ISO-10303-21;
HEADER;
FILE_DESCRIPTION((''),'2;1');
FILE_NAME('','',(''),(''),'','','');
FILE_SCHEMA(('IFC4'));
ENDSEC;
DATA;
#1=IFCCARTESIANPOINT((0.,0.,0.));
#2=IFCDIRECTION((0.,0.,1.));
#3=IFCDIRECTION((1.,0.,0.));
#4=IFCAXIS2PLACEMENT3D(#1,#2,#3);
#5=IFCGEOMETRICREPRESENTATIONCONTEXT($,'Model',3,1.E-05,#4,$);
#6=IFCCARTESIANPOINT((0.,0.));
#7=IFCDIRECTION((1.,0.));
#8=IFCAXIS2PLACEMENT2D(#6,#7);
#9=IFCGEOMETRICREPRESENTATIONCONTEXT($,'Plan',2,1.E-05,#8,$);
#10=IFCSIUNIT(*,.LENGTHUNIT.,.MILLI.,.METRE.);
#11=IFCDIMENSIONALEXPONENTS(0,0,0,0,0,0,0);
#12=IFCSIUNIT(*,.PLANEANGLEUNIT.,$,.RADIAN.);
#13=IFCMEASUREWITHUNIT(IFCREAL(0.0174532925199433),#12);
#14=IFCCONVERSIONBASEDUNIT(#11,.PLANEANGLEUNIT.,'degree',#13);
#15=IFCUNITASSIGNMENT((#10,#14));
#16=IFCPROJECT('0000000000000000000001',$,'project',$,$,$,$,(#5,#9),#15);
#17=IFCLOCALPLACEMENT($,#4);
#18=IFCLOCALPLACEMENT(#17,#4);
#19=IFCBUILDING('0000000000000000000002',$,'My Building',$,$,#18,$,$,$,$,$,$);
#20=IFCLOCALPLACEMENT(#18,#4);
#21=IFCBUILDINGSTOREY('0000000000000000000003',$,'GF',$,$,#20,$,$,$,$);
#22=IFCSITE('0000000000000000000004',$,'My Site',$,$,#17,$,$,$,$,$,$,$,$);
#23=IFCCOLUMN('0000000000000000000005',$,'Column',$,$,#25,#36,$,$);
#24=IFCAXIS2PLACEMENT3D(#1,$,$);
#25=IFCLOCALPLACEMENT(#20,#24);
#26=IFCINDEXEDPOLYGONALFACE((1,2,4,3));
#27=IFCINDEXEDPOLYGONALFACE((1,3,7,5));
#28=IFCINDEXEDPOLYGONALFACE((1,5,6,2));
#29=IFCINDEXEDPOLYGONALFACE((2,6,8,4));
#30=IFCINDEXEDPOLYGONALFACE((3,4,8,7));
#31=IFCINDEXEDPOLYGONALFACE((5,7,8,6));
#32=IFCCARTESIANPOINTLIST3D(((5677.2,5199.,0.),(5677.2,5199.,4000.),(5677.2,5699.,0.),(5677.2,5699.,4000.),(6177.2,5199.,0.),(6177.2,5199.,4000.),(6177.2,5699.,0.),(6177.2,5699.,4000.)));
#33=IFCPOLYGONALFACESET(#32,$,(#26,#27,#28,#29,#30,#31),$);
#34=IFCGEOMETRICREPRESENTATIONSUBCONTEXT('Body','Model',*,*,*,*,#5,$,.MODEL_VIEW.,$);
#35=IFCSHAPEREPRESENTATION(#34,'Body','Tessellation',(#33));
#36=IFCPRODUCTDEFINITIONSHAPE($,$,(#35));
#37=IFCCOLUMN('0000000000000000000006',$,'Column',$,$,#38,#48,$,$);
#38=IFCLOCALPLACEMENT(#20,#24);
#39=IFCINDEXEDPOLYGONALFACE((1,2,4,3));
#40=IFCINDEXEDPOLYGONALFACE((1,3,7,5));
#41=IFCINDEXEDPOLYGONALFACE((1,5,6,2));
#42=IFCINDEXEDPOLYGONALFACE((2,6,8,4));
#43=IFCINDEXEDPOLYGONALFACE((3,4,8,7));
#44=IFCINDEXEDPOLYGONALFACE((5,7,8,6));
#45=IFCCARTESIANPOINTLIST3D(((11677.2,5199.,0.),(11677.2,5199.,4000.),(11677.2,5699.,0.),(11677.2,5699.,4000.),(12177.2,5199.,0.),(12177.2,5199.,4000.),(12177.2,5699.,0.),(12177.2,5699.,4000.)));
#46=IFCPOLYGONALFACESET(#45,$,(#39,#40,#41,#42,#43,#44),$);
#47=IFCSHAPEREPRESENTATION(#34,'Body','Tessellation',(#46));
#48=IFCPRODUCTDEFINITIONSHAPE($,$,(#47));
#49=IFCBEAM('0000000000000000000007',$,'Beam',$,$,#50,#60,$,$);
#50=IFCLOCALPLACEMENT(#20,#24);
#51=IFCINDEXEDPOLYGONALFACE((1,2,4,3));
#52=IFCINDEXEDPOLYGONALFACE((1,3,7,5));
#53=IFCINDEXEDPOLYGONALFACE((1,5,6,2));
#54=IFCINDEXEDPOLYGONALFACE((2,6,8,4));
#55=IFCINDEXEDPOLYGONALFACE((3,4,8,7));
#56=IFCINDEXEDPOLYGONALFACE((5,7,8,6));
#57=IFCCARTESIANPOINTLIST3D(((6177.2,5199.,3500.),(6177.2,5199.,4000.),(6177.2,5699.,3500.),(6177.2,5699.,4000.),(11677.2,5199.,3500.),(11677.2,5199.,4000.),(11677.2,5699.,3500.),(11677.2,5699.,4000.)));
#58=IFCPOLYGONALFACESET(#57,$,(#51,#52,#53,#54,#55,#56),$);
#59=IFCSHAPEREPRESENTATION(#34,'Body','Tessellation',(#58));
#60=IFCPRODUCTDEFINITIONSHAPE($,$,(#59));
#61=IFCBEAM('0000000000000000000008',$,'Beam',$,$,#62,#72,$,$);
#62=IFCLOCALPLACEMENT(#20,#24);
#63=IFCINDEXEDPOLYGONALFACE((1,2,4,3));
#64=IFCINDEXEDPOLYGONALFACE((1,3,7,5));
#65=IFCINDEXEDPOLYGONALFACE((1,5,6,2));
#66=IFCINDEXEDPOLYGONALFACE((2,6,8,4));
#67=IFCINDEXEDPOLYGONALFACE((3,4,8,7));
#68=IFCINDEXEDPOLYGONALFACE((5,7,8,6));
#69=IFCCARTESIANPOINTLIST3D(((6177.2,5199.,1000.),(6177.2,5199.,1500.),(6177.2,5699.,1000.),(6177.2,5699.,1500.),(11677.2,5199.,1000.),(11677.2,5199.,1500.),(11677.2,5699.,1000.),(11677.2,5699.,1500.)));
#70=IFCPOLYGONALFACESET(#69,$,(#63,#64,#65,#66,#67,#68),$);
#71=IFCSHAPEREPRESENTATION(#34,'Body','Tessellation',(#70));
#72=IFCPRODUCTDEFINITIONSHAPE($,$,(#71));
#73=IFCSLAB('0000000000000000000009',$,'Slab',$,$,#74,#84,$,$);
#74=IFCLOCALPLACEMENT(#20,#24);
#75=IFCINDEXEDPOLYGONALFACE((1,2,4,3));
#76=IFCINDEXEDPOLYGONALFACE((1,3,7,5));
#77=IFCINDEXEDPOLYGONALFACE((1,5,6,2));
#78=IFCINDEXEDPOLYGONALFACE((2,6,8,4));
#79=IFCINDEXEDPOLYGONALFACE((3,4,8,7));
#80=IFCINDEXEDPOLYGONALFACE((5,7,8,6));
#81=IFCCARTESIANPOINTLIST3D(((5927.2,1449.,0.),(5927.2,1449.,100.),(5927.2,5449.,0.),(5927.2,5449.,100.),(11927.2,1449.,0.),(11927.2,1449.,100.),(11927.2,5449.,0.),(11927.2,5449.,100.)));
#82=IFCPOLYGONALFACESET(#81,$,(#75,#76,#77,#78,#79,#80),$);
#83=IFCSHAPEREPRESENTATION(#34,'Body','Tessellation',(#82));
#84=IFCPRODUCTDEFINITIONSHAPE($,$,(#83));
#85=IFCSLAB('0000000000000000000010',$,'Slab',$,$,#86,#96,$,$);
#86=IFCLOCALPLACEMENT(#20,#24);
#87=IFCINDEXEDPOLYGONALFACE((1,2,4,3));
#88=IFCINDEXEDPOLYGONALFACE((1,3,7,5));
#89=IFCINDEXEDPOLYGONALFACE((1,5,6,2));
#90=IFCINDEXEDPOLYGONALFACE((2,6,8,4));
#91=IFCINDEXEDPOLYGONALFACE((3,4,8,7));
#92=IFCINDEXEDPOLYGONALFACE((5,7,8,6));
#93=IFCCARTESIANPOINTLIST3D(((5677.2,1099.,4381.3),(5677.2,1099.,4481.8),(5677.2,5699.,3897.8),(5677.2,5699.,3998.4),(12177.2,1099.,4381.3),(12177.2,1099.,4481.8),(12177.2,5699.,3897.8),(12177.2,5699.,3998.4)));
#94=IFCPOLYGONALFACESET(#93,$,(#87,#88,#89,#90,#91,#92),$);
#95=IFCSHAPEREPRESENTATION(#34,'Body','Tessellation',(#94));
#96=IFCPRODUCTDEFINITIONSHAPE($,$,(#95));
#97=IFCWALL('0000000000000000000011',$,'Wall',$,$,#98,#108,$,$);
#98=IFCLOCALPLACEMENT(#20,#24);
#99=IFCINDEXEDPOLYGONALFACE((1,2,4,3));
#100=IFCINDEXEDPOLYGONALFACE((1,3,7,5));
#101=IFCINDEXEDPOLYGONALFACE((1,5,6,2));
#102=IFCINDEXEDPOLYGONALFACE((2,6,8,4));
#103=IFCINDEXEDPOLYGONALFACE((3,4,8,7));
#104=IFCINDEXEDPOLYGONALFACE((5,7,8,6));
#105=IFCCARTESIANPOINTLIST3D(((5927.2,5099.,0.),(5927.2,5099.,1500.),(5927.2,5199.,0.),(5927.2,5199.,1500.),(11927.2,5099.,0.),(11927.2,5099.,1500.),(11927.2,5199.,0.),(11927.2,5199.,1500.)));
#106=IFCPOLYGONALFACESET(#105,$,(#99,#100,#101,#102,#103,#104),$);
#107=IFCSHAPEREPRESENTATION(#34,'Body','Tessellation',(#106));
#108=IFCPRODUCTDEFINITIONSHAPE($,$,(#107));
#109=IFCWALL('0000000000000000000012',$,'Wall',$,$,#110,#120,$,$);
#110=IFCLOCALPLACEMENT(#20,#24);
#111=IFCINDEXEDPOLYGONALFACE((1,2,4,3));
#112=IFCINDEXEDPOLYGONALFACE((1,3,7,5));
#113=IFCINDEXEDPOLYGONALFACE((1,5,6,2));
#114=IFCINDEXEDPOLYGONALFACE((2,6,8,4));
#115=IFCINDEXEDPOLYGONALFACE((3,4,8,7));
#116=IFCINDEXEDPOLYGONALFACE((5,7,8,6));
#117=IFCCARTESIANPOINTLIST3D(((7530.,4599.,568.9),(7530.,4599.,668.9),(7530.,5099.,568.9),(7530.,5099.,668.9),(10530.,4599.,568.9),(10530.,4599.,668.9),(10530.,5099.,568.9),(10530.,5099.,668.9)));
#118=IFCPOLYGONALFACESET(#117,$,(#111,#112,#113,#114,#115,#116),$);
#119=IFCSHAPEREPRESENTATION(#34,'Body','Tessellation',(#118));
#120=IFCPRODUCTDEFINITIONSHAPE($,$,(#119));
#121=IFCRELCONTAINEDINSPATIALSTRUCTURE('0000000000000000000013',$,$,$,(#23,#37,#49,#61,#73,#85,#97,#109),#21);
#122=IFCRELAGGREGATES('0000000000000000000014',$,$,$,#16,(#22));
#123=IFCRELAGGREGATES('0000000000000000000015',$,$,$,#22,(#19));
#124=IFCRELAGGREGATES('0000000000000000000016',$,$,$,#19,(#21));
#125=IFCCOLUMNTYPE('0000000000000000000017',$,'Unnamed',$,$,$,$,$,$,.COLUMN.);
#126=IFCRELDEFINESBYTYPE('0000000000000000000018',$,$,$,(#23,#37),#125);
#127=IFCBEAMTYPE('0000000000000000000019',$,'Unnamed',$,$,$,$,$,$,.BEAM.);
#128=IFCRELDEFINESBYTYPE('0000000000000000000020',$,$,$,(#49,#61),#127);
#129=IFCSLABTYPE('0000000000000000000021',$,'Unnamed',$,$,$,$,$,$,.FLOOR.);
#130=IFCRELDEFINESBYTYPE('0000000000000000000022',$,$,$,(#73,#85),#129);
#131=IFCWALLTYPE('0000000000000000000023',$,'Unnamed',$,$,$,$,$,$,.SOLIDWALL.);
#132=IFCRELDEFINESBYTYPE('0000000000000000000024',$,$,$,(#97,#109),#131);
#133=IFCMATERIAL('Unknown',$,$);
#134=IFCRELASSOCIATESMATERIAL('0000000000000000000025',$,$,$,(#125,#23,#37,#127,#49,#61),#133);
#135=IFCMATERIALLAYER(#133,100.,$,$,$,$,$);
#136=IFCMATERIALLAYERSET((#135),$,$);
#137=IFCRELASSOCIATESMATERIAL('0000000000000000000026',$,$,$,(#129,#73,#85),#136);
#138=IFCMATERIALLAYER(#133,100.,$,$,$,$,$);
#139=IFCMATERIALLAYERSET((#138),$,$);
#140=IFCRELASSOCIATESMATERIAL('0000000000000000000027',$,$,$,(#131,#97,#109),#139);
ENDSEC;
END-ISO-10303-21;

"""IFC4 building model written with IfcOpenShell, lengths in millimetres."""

from ifc_helpers import new_model, entity, si_unit, converted_unit, frame, origin_with_axes, origin_2d_with_axis, place, context, subcontext, project, spatial, line, indexed_curve, rectangle, outline, extrude, material, layer, layer_set, layer_usage, material_profile, profile_set, profile_usage, type_object, element, save


model = new_model("IFC4")

# Units and contexts
model_context = context("Model", 3, precision=1e-05, world=origin_with_axes())
plan_context = context("Plan", 2, precision=1e-05, world=origin_2d_with_axis())
body_context = subcontext(model_context, "Body", "Model", "MODEL_VIEW")
ifc_project = project(units=[si_unit("LENGTHUNIT", "METRE", prefix="MILLI"), converted_unit("PLANEANGLEUNIT", "degree", entity("IfcReal", 0.0174532925199433), si_unit("PLANEANGLEUNIT", "RADIAN"), dimensions=[0, 0, 0, 0, 0, 0, 0])], contexts=[model_context, plan_context])

# Site, building, storey
site_placement = place(None, origin_with_axes())
site = spatial("IfcSite", under=ifc_project, at=site_placement, Name="My Site")
building_placement = place(site_placement, origin_with_axes())
building = spatial("IfcBuilding", under=site, at=building_placement, Name="My Building")
storey_placement = place(building_placement, origin_with_axes())
storey = spatial("IfcBuildingStorey", under=building, at=storey_placement, Name="GF")

# Columns
ifc_material = material(Name="Unknown")
ifc_material_profile_1 = material_profile(ifc_material, rectangle(XDim=500.0, YDim=500.0))
ifc_profile_set_1 = profile_set([ifc_material_profile_1])
ifc_profile_usage_1 = profile_usage(ifc_profile_set_1, cardinal=10)
column_type = type_object("IfcColumnType", Name="Unnamed", PredefinedType="COLUMN", material=ifc_profile_set_1)
column_1_placement = place(storey_placement, frame((5927.2, 5449.0, 0.0), z_axis=(0.0, 0.0, 1.0), x_axis=(1.0, 0.0, 0.0)))
element("IfcColumn", 1, at=column_1_placement, inside=storey, type_object=column_type, material=ifc_profile_usage_1, Name="Column", context=body_context, shape_type="SweptSolid", body=[
    extrude(rectangle(XDim=500.0, YDim=500.0), origin_with_axes(), (0.0, 0.0, 1.0), 4000.0),
])
ifc_profile_usage_2 = profile_usage(ifc_profile_set_1, cardinal=10)
column_2_placement = place(storey_placement, frame((11927.2, 5449.0, 0.0), z_axis=(0.0, 0.0, 1.0), x_axis=(1.0, 0.0, 0.0)))
element("IfcColumn", 2, at=column_2_placement, inside=storey, type_object=column_type, material=ifc_profile_usage_2, Name="Column", context=body_context, shape_type="SweptSolid", body=[
    extrude(rectangle(XDim=500.0, YDim=500.0), origin_with_axes(), (0.0, 0.0, 1.0), 4000.0),
])

# Beams
ifc_material_profile_2 = material_profile(ifc_material, rectangle(XDim=500.0, YDim=500.0))
ifc_profile_set_2 = profile_set([ifc_material_profile_2])
ifc_profile_usage_3 = profile_usage(ifc_profile_set_2, cardinal=7)
beam_type = type_object("IfcBeamType", Name="Unnamed", PredefinedType="BEAM", material=ifc_profile_set_2)
beam_1_placement = place(storey_placement, frame((6177.2, 5699.0, 4000.0), z_axis=(1.0, 0.0, 0.0), x_axis=(0.0, 1.0, 0.0)))
element("IfcBeam", 3, at=beam_1_placement, inside=storey, type_object=beam_type, material=ifc_profile_usage_3, Name="Beam", context=body_context, shape_type="SweptSolid", body=[
    extrude(rectangle(XDim=500.0, YDim=500.0), frame((-250.0, -250.0, 0.0), z_axis=(0.0, 0.0, 1.0), x_axis=(1.0, 0.0, 0.0)), (0.0, 0.0, 1.0), 5500.0),
])
ifc_profile_usage_4 = profile_usage(ifc_profile_set_2, cardinal=7)
beam_2_placement = place(storey_placement, frame((6177.2, 5699.0, 1500.0), z_axis=(1.0, 0.0, 0.0), x_axis=(0.0, 1.0, 0.0)))
element("IfcBeam", 4, at=beam_2_placement, inside=storey, type_object=beam_type, material=ifc_profile_usage_4, Name="Beam", context=body_context, shape_type="SweptSolid", body=[
    extrude(rectangle(XDim=500.0, YDim=500.0), frame((-250.0, -250.0, 0.0), z_axis=(0.0, 0.0, 1.0), x_axis=(1.0, 0.0, 0.0)), (0.0, 0.0, 1.0), 5500.0),
])

# Slabs
ifc_layer_1 = layer(ifc_material, 100.0)
ifc_layer_set_1 = layer_set([ifc_layer_1])
ifc_layer_usage_1 = layer_usage(ifc_layer_set_1, "AXIS3", "POSITIVE", -100.0)
slab_type = type_object("IfcSlabType", Name="Unnamed", PredefinedType="FLOOR", material=ifc_layer_set_1)
slab_1_placement = place(storey_placement, frame((5927.2, 5449.0, 100.0), z_axis=(0.0, 0.0, 1.0), x_axis=(1.0, 0.0, 0.0)))
element("IfcSlab", 5, at=slab_1_placement, inside=storey, type_object=slab_type, material=ifc_layer_usage_1, Name="Slab", context=body_context, shape_type="SweptSolid", body=[
    extrude(outline(indexed_curve([(0.0, 0.0), (0.0, -4000.0), (6000.0, -4000.0), (6000.0, 0.0), (0.0, 0.0)])), frame((0.0, 0.0, -100.0), z_axis=(0.0, 0.0, 1.0), x_axis=(1.0, 0.0, 0.0)), (0.0, 0.0, 1.0), 100.0),
])
ifc_layer_usage_2 = layer_usage(ifc_layer_set_1, "AXIS3", "POSITIVE", -100.0)
slab_2_placement = place(storey_placement, frame((5677.2, 5699.0, 3998.4), z_axis=(0.0, 0.104529, 0.994522), x_axis=(1.0, 0.0, 0.0)))
element("IfcSlab", 6, at=slab_2_placement, inside=storey, type_object=slab_type, material=ifc_layer_usage_2, Name="Slab", context=body_context, shape_type="SweptSolid", body=[
    extrude(outline(indexed_curve([(0.0, 0.0), (6500.0, 0.0), (6500.0, -4625.3), (0.0, -4625.3), (0.0, 0.0)])), frame((0.0, 10.5, -100.0), z_axis=(0.0, 0.0, 1.0), x_axis=(1.0, 0.0, 0.0)), (0.0, -0.104528, 0.994522), 100.6),
])

# Walls
ifc_layer_2 = layer(ifc_material, 100.0)
ifc_layer_set_2 = layer_set([ifc_layer_2])
ifc_layer_usage_3 = layer_usage(ifc_layer_set_2, "AXIS2", "POSITIVE", 0.0)
wall_type = type_object("IfcWallType", Name="Unnamed", PredefinedType="SOLIDWALL", material=ifc_layer_set_2)
wall_1_placement = place(storey_placement, frame((11927.2, 5199.0, 0.0), z_axis=(0.0, 0.0, 1.0), x_axis=(-1.0, 0.0, 0.0)))
element("IfcWall", 7, at=wall_1_placement, inside=storey, type_object=wall_type, material=ifc_layer_usage_3, Name="Wall", context=body_context, shape_type="SweptSolid", body=[
    extrude(outline(indexed_curve([(0.0, 0.0), (0.0, 100.0), (6000.0, 100.0), (6000.0, 0.0)], segments=[line(1, 2, 3, 4, 1)])), origin_with_axes(), (0.0, 0.0, 1.0), 1500.0),
])
ifc_layer_usage_4 = layer_usage(ifc_layer_set_2, "AXIS2", "POSITIVE", 0.0)
wall_2_placement = place(storey_placement, frame((7530.0, 4599.0, 568.9), z_axis=(1.0, 0.0, -0.00001), x_axis=(0.0, 1.0, 0.0)))
element("IfcWall", 8, at=wall_2_placement, inside=storey, type_object=wall_type, material=ifc_layer_usage_4, Name="Wall", context=body_context, shape_type="SweptSolid", body=[
    extrude(outline(indexed_curve([(0.0, 0.0), (0.0, 100.0), (500.0, 100.0), (500.0, 0.0)], segments=[line(1, 2, 3, 4, 1)])), origin_with_axes(), (0.0, 0.0, 1.0), 3000.0),
])

save(model, "model.ifc")
